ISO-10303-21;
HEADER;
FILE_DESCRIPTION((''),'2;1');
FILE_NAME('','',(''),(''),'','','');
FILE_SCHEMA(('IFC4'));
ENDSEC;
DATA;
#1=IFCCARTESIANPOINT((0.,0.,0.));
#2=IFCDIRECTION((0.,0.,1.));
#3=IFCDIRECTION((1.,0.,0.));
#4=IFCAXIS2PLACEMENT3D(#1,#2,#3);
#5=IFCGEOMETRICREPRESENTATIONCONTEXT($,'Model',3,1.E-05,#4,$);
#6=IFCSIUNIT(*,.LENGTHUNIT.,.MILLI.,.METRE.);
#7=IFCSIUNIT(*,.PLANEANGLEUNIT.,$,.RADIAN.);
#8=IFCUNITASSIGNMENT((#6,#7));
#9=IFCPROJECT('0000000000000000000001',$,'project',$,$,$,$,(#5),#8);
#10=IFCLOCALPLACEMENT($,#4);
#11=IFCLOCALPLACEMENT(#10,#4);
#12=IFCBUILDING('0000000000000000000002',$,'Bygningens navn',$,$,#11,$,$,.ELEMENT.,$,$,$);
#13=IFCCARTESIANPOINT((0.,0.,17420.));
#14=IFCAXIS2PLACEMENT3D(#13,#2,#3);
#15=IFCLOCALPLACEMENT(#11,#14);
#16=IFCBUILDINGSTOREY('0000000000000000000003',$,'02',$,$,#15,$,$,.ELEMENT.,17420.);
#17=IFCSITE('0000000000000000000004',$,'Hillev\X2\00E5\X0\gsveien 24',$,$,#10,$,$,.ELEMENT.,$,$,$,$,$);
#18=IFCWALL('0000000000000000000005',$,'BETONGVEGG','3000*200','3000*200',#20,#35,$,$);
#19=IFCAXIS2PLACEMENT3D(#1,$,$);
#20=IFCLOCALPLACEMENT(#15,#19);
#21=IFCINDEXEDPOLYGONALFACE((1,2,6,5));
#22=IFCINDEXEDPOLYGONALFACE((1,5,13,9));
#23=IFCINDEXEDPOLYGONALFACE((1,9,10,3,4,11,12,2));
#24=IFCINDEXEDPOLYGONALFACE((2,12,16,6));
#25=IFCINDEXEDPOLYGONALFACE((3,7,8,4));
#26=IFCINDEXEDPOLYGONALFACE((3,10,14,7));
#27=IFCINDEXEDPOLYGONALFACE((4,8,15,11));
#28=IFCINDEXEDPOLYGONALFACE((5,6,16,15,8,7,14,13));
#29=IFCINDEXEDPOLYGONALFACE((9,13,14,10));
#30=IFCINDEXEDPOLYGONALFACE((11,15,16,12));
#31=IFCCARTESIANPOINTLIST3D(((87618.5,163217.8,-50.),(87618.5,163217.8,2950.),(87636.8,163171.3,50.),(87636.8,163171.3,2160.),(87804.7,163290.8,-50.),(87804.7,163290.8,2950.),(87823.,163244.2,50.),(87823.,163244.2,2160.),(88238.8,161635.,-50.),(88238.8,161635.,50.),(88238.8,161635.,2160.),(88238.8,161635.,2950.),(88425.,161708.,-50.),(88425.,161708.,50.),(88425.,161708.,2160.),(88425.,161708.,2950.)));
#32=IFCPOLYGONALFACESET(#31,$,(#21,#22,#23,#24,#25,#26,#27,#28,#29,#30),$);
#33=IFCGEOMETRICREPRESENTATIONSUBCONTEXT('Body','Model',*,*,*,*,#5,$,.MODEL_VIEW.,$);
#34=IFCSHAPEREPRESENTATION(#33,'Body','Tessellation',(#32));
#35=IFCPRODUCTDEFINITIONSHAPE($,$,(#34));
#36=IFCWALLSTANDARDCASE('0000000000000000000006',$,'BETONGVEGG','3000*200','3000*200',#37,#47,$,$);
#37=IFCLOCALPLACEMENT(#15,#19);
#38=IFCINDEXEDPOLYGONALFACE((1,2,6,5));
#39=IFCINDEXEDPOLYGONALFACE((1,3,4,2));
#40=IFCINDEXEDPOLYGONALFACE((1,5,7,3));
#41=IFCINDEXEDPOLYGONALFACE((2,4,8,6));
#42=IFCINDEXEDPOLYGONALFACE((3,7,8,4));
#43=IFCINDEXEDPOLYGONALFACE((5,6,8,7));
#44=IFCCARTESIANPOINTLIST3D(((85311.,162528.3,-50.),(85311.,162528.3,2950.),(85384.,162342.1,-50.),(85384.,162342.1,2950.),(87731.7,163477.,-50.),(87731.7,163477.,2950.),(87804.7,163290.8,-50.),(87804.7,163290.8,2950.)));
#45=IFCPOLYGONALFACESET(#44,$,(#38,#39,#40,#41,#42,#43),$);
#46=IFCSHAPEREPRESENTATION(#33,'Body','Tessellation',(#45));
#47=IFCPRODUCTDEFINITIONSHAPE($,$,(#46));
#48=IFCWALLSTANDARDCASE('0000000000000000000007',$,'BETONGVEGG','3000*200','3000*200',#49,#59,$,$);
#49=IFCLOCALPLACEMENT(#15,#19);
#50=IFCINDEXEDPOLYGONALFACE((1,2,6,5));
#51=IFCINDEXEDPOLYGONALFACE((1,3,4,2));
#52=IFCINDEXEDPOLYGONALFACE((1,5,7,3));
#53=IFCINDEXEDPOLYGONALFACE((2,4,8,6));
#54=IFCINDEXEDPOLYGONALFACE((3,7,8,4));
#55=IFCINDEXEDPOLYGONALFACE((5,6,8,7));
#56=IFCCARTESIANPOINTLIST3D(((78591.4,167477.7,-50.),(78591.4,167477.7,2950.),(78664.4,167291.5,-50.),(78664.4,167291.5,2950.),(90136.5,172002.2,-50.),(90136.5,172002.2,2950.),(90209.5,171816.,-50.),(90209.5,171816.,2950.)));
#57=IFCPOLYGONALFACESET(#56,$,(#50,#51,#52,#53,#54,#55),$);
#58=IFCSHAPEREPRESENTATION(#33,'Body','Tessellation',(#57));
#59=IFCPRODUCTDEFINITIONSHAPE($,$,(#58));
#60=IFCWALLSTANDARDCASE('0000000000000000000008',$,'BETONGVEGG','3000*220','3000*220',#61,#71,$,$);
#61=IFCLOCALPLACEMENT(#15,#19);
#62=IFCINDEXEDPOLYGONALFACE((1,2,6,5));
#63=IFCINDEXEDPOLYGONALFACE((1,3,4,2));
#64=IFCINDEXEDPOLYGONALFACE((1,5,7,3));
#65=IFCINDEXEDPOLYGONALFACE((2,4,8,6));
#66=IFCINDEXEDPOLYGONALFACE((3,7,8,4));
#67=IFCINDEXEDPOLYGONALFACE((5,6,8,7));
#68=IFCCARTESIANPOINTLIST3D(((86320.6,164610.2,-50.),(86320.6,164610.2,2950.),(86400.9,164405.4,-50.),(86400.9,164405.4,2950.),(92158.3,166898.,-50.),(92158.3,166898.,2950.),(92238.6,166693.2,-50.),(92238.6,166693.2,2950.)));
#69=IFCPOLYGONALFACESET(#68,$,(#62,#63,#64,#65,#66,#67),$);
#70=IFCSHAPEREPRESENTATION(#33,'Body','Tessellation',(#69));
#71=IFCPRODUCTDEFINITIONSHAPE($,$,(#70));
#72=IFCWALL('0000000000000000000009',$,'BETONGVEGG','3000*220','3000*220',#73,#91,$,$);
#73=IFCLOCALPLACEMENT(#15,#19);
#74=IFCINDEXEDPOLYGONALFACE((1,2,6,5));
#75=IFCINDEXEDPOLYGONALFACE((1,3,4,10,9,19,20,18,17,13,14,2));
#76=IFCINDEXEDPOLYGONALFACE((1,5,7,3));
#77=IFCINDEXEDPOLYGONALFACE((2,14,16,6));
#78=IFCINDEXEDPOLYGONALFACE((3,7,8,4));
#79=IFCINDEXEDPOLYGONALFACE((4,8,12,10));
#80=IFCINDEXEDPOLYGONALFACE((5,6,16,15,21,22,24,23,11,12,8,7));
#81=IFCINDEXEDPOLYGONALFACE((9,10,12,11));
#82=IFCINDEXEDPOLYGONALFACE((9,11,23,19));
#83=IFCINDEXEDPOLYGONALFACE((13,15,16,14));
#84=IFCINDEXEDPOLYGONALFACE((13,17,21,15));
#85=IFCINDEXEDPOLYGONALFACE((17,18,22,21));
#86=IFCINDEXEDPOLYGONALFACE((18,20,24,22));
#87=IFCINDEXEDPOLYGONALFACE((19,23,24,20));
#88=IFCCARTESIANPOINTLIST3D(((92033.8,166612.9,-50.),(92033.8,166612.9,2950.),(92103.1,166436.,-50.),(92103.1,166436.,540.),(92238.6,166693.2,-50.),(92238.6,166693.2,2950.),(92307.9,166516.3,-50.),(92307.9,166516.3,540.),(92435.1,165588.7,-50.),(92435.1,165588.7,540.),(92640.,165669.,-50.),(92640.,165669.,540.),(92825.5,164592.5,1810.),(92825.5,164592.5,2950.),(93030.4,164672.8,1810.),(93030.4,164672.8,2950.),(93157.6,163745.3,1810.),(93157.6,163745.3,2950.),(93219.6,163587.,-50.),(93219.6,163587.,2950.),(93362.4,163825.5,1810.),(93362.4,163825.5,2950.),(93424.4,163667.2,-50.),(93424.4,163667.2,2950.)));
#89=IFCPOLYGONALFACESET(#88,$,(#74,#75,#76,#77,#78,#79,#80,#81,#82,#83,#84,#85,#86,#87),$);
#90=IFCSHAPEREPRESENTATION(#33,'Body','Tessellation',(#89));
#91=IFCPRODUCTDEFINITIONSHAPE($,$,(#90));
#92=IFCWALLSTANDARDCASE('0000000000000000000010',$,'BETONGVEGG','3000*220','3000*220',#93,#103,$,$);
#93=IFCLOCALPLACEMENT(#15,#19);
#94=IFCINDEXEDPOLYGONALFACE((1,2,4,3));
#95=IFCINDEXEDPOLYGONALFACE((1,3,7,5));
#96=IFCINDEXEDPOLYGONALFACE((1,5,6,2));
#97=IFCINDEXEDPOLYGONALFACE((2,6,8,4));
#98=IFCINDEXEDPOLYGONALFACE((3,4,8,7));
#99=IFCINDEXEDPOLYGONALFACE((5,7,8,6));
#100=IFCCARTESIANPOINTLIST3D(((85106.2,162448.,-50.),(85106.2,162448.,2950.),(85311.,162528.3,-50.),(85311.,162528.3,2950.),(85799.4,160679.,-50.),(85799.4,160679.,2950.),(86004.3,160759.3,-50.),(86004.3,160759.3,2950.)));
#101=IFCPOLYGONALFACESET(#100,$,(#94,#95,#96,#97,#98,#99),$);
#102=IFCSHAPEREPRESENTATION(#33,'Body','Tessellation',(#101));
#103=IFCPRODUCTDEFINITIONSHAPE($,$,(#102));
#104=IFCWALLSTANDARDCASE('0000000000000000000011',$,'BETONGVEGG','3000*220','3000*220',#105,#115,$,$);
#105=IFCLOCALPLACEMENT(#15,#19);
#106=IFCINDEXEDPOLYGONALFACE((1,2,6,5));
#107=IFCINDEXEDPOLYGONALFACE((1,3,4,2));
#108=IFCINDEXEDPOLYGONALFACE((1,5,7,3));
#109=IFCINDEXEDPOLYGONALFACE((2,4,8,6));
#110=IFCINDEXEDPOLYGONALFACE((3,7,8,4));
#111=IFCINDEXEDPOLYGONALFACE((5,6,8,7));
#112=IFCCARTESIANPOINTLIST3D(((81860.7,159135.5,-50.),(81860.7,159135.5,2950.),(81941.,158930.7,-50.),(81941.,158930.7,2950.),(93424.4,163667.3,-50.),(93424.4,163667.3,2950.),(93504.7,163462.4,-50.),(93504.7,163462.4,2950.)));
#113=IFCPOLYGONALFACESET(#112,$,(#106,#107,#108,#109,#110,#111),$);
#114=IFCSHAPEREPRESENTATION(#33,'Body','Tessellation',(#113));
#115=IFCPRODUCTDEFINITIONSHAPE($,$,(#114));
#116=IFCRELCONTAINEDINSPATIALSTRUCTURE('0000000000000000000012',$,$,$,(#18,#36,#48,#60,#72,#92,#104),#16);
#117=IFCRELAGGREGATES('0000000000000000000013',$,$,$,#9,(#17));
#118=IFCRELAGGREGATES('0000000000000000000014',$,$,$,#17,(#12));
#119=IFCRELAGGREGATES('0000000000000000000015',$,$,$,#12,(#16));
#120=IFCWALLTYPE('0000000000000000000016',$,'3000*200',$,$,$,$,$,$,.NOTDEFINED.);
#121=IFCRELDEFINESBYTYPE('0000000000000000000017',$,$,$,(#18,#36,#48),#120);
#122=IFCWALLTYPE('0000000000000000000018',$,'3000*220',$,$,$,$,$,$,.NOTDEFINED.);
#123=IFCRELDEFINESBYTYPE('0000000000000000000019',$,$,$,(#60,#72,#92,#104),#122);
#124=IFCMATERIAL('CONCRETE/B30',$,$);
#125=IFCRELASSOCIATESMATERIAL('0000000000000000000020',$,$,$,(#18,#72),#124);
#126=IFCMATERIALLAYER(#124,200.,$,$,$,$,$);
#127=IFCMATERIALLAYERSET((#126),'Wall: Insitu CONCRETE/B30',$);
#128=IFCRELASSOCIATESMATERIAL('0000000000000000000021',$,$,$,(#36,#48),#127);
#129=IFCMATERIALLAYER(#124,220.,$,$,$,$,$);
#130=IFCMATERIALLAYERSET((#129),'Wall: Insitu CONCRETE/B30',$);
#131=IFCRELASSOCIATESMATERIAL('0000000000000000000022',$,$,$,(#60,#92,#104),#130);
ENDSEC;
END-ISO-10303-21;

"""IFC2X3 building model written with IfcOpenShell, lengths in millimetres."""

from ifc_helpers import new_model, si_unit, frame, frame_2d, origin_with_axes, place, context, subcontext, project, spatial, rectangle, extrude, boolean, material, layer, layer_set, layer_usage, type_object, element, save


model = new_model("IFC2X3")

# Units and contexts
model_context = context("Model", 3, precision=1e-05, world=origin_with_axes())
body_context = subcontext(model_context, "Body", "Model", "MODEL_VIEW")
ifc_project = project(units=[si_unit("LENGTHUNIT", "METRE", prefix="MILLI"), si_unit("PLANEANGLEUNIT", "RADIAN")], contexts=[model_context])

# Site, building, storey
site_placement = place(None, origin_with_axes())
site = spatial("IfcSite", under=ifc_project, at=site_placement, Name="Hillevågsveien 24", CompositionType="ELEMENT")
building_placement = place(site_placement, origin_with_axes())
building = spatial("IfcBuilding", under=site, at=building_placement, Name="Bygningens navn", CompositionType="ELEMENT")
storey_placement = place(building_placement, frame((0.0, 0.0, 17420.0), z_axis=(0.0, 0.0, 1.0), x_axis=(1.0, 0.0, 0.0)))
storey = spatial("IfcBuildingStorey", under=building, at=storey_placement, Name="02", CompositionType="ELEMENT", Elevation=17420.0)

# Shared definitions
ifc_material_1 = material(Name="CONCRETE/B30")

# Walls
ifc_layer_1 = layer(ifc_material_1, 200.0)
ifc_layer_set_1 = layer_set([ifc_layer_1], Name="Wall: Insitu CONCRETE/B30")
wall_type_1 = type_object("IfcWallType", Name="3000*200", PredefinedType="NOTDEFINED")
wall_1_placement = place(storey_placement, frame((88331.9, 161671.5, -50.0), z_axis=(0.0, 0.0, 1.0), x_axis=(-0.364878, 0.931055, 0.0)))
element("IfcWall", 1, at=wall_1_placement, inside=storey, type_object=wall_type_1, material=ifc_material_1, Name="BETONGVEGG", Description="3000*200", ObjectType="3000*200", context=body_context, shape_type="CSG", body=[
    boolean("DIFFERENCE", extrude(rectangle(XDim=1700.0, YDim=200.0, at=frame_2d((0.0, 850.0), x_axis=(0.0, -1.0))), frame((0.0, 0.0, 0.0), z_axis=(0.0, 0.0, 1.0), x_axis=(0.0, -1.0, 0.0)), (0.0, 0.0, 1.0), 3000.0), extrude(rectangle(XDim=1650.0, YDim=500.0, at=frame_2d((0.0, 825.0), x_axis=(0.0, -1.0))), frame((0.0, -99.9, 100.0), z_axis=(0.0, 0.0, 1.0), x_axis=(0.0, -1.0, 0.0)), (0.0, 0.0, 1.0), 2110.0)),
])
ifc_layer_usage_1 = layer_usage(ifc_layer_set_1, "AXIS2", "POSITIVE", -100.0)
wall_2_placement = place(storey_placement, frame((85347.5, 162435.2, -50.0), z_axis=(0.0, 0.0, 1.0), x_axis=(0.931056, 0.364876, 0.0)))
element("IfcWallStandardCase", 2, at=wall_2_placement, inside=storey, type_object=wall_type_1, material=ifc_layer_usage_1, Name="BETONGVEGG", Description="3000*200", ObjectType="3000*200", context=body_context, shape_type="SweptSolid", body=[
    extrude(rectangle(XDim=2599.9, YDim=200.0, at=frame_2d((0.0, 1300.0), x_axis=(0.0, -1.0))), frame((0.0, 0.0, 0.0), z_axis=(0.0, 0.0, 1.0), x_axis=(0.0, -1.0, 0.0)), (0.0, 0.0, 1.0), 3000.0),
])
ifc_layer_usage_2 = layer_usage(ifc_layer_set_1, "AXIS2", "POSITIVE", -100.0)
wall_3_placement = place(storey_placement, frame((78627.9, 167384.6, -50.0), z_axis=(0.0, 0.0, 1.0), x_axis=(0.931056, 0.364877, 0.0)))
element("IfcWallStandardCase", 3, at=wall_3_placement, inside=storey, type_object=wall_type_1, material=ifc_layer_usage_2, Name="BETONGVEGG", Description="3000*200", ObjectType="3000*200", context=body_context, shape_type="SweptSolid", body=[
    extrude(rectangle(XDim=12400.0, YDim=200.0, at=frame_2d((0.0, 6200.0), x_axis=(0.0, -1.0))), frame((0.0, 0.0, 0.0), z_axis=(0.0, 0.0, 1.0), x_axis=(0.0, -1.0, 0.0)), (0.0, 0.0, 1.0), 3000.0),
])
ifc_layer_2 = layer(ifc_material_1, 220.0)
ifc_layer_set_2 = layer_set([ifc_layer_2], Name="Wall: Insitu CONCRETE/B30")
ifc_layer_usage_3 = layer_usage(ifc_layer_set_2, "AXIS2", "POSITIVE", -110.0)
wall_type_2 = type_object("IfcWallType", Name="3000*220", PredefinedType="NOTDEFINED")
wall_4_placement = place(storey_placement, frame((86360.7, 164507.8, -50.0), z_axis=(0.0, 0.0, 1.0), x_axis=(0.931056, 0.364877, 0.0)))
element("IfcWallStandardCase", 4, at=wall_4_placement, inside=storey, type_object=wall_type_2, material=ifc_layer_usage_3, Name="BETONGVEGG", Description="3000*220", ObjectType="3000*220", context=body_context, shape_type="SweptSolid", body=[
    extrude(rectangle(XDim=6270.0, YDim=220.0, at=frame_2d((0.0, 3135.0), x_axis=(0.0, -1.0))), frame((0.0, 0.0, 0.0), z_axis=(0.0, 0.0, 1.0), x_axis=(0.0, -1.0, 0.0)), (0.0, 0.0, 1.0), 3000.0),
])
wall_5_placement = place(storey_placement, frame((93322.0, 163627.1, -50.0), z_axis=(0.0, 0.0, 1.0), x_axis=(-0.364877, 0.931056, 0.0)))
element("IfcWall", 5, at=wall_5_placement, inside=storey, type_object=wall_type_2, material=ifc_material_1, Name="BETONGVEGG", Description="3000*220", ObjectType="3000*220", context=body_context, shape_type="CSG", body=[
    boolean("DIFFERENCE", boolean("DIFFERENCE", extrude(rectangle(XDim=3250.0, YDim=220.0, at=frame_2d((0.0, 1625.0), x_axis=(0.0, -1.0))), frame((0.0, 0.0, 0.0), z_axis=(0.0, 0.0, 1.0), x_axis=(0.0, -1.0, 0.0)), (0.0, 0.0, 1.0), 3000.0), extrude(rectangle(XDim=910.0, YDim=500.0, at=frame_2d((0.0, 455.0), x_axis=(0.0, -1.0))), frame((2150.0, 0.0, -1620.0), z_axis=(0.0, 0.0, 1.0), x_axis=(-0.000002, -1.0, 0.0)), (0.0, 0.0, 1.0), 2210.0)), extrude(rectangle(XDim=910.0, YDim=500.0, at=frame_2d((0.0, 455.0), x_axis=(0.0, -1.0))), frame((170.0, 0.0, 1860.0), z_axis=(0.0, 0.0, 1.0), x_axis=(-0.000002, -1.0, 0.0)), (0.0, 0.0, 1.0), 2210.0)),
])
ifc_layer_usage_4 = layer_usage(ifc_layer_set_2, "AXIS2", "POSITIVE", -110.0)
wall_6_placement = place(storey_placement, frame((85208.6, 162488.2, -50.0), z_axis=(0.0, 0.0, 1.0), x_axis=(0.364878, -0.931056, 0.0)))
element("IfcWallStandardCase", 6, at=wall_6_placement, inside=storey, type_object=wall_type_2, material=ifc_layer_usage_4, Name="BETONGVEGG", Description="3000*220", ObjectType="3000*220", context=body_context, shape_type="SweptSolid", body=[
    extrude(rectangle(XDim=1900.0, YDim=220.0, at=frame_2d((0.0, 950.0), x_axis=(0.0, -1.0))), frame((0.0, 0.0, 0.0), z_axis=(0.0, 0.0, 1.0), x_axis=(0.0, -1.0, 0.0)), (0.0, 0.0, 1.0), 3000.0),
])
ifc_layer_usage_5 = layer_usage(ifc_layer_set_2, "AXIS2", "POSITIVE", -110.0)
wall_7_placement = place(storey_placement, frame((81900.9, 159033.1, -50.0), z_axis=(0.0, 0.0, 1.0), x_axis=(0.931056, 0.364877, 0.0)))
element("IfcWallStandardCase", 7, at=wall_7_placement, inside=storey, type_object=wall_type_2, material=ifc_layer_usage_5, Name="BETONGVEGG", Description="3000*220", ObjectType="3000*220", context=body_context, shape_type="SweptSolid", body=[
    extrude(rectangle(XDim=12420.0, YDim=220.0, at=frame_2d((0.0, 6210.0), x_axis=(0.0, -1.0))), frame((0.0, 0.0, 0.0), z_axis=(0.0, 0.0, 1.0), x_axis=(0.0, -1.0, 0.0)), (0.0, 0.0, 1.0), 3000.0),
])

save(model, "model.ifc")
